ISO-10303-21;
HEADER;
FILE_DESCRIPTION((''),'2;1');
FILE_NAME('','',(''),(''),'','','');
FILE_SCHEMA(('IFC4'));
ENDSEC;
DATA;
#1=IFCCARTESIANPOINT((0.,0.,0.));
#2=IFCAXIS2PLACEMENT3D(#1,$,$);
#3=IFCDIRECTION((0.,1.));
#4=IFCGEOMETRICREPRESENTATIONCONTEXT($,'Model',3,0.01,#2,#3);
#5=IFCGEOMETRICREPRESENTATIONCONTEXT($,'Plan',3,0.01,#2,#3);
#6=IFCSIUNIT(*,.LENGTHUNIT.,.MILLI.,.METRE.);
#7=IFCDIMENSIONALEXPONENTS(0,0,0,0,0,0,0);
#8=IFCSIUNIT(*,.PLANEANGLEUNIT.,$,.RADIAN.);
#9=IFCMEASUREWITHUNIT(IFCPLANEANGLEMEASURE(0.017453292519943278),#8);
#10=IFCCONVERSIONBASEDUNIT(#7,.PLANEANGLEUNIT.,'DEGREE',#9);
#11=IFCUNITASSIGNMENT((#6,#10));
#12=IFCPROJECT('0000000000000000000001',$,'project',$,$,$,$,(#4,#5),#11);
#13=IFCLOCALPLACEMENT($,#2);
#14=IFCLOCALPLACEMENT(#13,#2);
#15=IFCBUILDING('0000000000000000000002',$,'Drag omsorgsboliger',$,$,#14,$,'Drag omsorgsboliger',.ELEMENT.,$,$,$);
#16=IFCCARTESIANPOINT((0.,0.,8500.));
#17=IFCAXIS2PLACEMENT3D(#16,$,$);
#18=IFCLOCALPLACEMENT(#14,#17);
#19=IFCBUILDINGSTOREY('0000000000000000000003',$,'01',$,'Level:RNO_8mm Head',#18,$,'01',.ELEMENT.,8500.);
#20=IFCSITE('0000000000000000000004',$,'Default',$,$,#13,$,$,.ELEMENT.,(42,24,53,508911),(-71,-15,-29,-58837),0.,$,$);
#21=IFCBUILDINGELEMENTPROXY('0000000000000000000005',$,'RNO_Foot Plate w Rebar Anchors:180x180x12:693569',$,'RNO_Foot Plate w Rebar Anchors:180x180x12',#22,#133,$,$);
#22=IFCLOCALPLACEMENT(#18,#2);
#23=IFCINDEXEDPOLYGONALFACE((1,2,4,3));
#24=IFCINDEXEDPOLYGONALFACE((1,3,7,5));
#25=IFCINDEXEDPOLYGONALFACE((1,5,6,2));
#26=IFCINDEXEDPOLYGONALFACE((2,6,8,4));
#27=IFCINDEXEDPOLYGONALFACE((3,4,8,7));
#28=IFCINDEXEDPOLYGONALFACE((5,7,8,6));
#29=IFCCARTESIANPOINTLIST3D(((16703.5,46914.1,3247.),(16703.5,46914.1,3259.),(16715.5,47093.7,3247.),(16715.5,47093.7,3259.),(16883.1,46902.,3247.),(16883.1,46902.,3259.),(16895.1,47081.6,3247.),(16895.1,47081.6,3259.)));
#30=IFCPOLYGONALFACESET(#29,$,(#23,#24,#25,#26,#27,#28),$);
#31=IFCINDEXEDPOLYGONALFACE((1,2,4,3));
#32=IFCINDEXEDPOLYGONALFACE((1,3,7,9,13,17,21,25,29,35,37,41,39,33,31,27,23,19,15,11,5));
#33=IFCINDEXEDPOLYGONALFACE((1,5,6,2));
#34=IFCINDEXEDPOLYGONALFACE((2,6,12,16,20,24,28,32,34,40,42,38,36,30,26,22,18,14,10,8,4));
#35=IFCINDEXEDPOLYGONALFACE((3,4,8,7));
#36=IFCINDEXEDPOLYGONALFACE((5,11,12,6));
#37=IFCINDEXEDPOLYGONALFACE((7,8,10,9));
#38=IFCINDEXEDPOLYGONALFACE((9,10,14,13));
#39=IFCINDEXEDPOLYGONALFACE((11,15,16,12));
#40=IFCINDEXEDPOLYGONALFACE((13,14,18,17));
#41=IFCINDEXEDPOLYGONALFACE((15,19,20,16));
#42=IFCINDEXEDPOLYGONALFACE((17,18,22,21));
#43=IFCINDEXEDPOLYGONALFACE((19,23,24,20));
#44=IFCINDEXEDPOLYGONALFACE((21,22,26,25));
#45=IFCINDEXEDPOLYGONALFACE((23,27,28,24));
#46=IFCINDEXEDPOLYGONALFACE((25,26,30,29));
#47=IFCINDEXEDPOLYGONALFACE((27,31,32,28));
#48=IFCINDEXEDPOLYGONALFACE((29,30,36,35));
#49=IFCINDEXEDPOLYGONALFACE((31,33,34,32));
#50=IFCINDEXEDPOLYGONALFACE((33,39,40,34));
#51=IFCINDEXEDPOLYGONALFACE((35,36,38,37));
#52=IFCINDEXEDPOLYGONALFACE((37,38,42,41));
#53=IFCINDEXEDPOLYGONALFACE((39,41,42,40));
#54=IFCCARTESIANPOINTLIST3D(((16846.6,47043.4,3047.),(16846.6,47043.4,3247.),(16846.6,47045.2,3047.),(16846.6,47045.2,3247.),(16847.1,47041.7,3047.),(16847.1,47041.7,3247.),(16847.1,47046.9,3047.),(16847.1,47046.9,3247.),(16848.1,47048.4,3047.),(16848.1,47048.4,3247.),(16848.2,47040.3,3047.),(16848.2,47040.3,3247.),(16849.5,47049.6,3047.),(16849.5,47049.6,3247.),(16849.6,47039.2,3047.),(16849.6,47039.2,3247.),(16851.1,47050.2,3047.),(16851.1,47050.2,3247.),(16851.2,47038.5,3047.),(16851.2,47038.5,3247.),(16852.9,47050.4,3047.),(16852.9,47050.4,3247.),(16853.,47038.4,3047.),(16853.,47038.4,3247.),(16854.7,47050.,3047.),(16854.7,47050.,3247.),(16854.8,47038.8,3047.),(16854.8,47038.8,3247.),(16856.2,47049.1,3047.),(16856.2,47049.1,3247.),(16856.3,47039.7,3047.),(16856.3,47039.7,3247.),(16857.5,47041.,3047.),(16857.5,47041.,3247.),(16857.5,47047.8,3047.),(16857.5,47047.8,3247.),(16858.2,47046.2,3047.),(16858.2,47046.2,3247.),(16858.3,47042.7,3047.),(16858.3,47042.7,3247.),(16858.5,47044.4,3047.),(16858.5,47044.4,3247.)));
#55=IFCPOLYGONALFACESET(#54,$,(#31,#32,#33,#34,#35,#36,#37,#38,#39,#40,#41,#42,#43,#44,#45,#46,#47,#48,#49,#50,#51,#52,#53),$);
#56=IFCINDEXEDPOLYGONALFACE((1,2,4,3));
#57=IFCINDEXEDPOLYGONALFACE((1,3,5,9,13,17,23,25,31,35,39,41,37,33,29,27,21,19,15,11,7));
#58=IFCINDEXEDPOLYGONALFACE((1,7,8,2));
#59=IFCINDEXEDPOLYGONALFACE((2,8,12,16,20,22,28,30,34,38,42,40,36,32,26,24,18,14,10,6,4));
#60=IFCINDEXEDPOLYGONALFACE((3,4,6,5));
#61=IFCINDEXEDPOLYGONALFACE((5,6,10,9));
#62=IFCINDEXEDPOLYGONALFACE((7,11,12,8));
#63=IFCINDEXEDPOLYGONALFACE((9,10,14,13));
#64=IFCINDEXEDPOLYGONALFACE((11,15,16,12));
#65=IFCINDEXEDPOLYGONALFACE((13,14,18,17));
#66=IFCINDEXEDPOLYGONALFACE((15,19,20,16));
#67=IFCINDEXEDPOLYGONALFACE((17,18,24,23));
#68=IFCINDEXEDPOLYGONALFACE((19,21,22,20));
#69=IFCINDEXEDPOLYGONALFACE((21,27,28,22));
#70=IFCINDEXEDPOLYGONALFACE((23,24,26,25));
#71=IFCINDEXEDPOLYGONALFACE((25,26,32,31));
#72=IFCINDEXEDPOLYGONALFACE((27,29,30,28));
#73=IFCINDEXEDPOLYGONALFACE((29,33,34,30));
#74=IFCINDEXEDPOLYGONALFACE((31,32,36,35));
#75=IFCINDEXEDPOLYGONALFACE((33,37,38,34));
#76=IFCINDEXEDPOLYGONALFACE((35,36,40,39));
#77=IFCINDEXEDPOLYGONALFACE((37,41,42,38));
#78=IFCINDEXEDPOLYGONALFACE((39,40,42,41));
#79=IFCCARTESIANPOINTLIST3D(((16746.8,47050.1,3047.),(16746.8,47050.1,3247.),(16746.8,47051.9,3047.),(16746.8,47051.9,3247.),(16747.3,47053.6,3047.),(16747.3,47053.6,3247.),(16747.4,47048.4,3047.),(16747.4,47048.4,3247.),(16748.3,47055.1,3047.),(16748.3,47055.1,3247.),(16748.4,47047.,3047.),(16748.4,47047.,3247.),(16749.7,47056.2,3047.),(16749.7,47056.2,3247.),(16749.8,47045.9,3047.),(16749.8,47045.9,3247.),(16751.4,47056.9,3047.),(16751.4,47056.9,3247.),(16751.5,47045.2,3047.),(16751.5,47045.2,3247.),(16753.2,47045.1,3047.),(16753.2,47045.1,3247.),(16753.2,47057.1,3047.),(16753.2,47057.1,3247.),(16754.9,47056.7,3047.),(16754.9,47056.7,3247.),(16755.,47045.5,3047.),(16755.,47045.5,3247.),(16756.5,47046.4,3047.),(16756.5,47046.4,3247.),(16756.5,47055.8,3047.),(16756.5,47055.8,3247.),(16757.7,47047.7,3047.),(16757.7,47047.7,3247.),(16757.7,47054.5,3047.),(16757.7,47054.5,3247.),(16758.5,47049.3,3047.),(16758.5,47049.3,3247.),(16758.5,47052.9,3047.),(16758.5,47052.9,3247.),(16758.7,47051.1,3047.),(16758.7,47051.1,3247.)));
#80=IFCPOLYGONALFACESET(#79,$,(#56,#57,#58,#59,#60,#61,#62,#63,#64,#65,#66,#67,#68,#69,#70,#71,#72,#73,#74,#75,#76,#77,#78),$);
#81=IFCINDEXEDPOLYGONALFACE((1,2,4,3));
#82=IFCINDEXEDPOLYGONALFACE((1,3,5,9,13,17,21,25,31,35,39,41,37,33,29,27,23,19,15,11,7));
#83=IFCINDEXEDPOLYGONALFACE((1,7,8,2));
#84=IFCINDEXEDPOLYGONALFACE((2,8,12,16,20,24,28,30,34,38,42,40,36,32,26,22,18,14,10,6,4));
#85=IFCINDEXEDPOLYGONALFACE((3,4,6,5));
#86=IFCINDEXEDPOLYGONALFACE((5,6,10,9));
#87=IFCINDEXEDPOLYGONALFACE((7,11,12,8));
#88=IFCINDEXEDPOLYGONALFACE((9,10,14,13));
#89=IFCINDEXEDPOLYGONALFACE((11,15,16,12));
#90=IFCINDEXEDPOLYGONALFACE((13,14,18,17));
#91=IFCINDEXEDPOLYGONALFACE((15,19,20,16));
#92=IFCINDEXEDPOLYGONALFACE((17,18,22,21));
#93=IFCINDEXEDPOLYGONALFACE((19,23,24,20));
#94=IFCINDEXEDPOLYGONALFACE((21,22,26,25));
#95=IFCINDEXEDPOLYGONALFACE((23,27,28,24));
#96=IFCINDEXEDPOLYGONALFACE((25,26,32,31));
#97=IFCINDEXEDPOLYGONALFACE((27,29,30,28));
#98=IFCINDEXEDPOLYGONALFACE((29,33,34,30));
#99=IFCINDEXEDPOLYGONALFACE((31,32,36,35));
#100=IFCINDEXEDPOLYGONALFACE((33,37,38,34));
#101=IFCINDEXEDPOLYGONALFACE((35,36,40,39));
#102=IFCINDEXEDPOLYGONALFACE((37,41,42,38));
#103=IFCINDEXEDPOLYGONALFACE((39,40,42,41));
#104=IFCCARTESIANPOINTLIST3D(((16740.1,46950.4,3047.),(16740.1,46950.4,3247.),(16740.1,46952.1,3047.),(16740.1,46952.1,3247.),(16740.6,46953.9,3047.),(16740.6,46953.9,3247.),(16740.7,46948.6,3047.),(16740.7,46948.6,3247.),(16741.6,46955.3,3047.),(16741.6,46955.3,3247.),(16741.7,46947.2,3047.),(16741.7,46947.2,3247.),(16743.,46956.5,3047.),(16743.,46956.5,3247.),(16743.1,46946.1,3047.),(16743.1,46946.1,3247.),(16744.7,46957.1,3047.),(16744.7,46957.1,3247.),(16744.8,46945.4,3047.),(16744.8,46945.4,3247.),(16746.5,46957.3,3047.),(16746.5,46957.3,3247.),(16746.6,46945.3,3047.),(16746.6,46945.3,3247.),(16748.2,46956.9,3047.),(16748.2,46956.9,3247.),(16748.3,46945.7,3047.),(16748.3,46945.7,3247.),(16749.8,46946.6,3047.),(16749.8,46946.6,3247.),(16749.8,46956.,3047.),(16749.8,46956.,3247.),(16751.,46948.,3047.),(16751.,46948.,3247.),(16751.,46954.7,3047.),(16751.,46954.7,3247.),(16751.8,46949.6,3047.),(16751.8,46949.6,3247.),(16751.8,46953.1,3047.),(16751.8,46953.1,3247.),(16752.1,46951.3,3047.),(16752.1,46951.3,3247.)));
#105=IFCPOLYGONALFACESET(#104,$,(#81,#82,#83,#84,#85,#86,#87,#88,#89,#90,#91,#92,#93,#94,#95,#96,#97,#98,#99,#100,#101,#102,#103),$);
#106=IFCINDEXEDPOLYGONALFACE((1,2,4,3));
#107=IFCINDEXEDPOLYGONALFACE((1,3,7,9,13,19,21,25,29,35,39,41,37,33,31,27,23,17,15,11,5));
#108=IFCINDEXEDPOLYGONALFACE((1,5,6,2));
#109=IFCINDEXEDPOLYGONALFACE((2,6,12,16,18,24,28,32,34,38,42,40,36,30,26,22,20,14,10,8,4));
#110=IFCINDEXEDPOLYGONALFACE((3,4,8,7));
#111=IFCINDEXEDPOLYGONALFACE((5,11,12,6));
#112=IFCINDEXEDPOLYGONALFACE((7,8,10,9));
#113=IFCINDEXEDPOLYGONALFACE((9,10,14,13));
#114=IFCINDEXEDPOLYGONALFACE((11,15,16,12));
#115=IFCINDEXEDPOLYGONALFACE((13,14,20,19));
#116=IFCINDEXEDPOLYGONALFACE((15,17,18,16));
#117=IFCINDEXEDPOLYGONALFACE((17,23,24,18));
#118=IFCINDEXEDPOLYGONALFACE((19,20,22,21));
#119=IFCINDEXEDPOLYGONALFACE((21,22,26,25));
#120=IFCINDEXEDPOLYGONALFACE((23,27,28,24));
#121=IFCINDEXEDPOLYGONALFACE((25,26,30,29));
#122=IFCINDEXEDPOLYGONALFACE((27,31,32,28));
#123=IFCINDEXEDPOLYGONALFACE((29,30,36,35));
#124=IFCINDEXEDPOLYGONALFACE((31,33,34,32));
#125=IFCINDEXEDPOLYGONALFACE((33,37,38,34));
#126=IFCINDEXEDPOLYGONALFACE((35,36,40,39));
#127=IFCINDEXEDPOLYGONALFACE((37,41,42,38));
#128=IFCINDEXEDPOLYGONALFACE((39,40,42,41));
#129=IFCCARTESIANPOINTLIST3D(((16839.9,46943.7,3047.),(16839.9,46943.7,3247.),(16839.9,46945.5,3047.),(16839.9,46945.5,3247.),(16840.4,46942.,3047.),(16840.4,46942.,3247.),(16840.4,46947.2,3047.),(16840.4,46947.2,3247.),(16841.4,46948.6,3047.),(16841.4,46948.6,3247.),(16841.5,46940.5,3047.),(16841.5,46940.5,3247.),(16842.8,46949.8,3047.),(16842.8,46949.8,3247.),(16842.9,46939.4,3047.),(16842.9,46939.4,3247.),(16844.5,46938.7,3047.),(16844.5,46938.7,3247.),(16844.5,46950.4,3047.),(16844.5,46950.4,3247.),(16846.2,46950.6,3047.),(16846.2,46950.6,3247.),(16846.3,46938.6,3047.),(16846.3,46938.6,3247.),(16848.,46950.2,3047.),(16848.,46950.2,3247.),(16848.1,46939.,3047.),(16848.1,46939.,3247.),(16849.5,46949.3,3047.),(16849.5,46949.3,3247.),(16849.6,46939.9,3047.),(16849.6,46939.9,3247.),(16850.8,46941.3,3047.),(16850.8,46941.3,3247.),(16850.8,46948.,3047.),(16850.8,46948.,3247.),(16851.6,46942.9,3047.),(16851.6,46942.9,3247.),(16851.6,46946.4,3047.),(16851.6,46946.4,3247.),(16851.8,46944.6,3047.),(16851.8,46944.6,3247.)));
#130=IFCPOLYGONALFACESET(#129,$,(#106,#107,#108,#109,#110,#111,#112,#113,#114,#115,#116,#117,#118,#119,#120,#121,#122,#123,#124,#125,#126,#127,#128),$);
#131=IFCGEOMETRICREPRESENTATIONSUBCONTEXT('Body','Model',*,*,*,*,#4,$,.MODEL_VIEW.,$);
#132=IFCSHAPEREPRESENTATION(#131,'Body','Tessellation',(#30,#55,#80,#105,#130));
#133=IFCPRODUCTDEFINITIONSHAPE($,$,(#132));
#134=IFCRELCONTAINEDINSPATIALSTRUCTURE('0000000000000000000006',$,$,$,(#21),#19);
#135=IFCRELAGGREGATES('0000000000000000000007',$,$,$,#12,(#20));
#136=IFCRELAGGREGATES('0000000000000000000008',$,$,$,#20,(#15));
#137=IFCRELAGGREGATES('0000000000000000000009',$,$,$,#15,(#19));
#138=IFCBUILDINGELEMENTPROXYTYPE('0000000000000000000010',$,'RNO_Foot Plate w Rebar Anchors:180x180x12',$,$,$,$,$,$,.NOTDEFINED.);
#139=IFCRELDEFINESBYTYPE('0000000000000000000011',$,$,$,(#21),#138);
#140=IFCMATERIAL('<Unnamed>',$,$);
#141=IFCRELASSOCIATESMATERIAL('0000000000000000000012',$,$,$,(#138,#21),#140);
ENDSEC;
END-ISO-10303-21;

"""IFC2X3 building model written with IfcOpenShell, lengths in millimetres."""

from ifc_helpers import new_model, entity, si_unit, converted_unit, direction, frame, frame_2d, origin, origin_2d_with_axis, place, context, subcontext, project, spatial, rectangle, circle, extrude, source, transform, mapped, material, type_object, type_shapes, element, save


model = new_model("IFC2X3")

# Units and contexts
model_context = context("Model", 3, precision=0.01, world=origin(), true_north=direction((0.0, 1.0)))
plan_context = context("Plan", 3, precision=0.01, world=origin(), true_north=direction((0.0, 1.0)))
body_context = subcontext(model_context, "Body", "Model", "MODEL_VIEW")
ifc_project = project(units=[si_unit("LENGTHUNIT", "METRE", prefix="MILLI"), converted_unit("PLANEANGLEUNIT", "DEGREE", entity("IfcPlaneAngleMeasure", 0.017453292519943278), si_unit("PLANEANGLEUNIT", "RADIAN"), dimensions=[0, 0, 0, 0, 0, 0, 0])], contexts=[model_context, plan_context])

# Site, building, storey
site_placement = place(None, origin())
site = spatial("IfcSite", under=ifc_project, at=site_placement, Name="Default", CompositionType="ELEMENT", RefLatitude=(42, 24, 53, 508911), RefLongitude=(-71, -15, -29, -58837), RefElevation=0.0)
building_placement = place(site_placement, origin())
building = spatial("IfcBuilding", under=site, at=building_placement, Name="Drag omsorgsboliger", LongName="Drag omsorgsboliger", CompositionType="ELEMENT")
storey_placement = place(building_placement, frame((0.0, 0.0, 8500.0)))
storey = spatial("IfcBuildingStorey", under=building, at=storey_placement, Name="01", ObjectType="Level:RNO_8mm Head", LongName="01", CompositionType="ELEMENT", Elevation=8500.0)

# Building element proxy
ifc_material_1 = material(Name="<Unnamed>")
building_element_proxy_type_1 = type_object("IfcBuildingElementProxyType", Name="RNO_Foot Plate w Rebar Anchors:180x180x12", PredefinedType="NOTDEFINED", material=ifc_material_1)
shared_shape_1 = source(origin(), body_context, "Body", "SweptSolid", [
    extrude(rectangle(XDim=180.0, YDim=180.0, at=origin_2d_with_axis()), frame((-90.0, 20.0, -12.0), z_axis=(0.0, 0.0, 1.0), x_axis=(-1.0, 0.0, 0.0)), (0.0, 0.0, 1.0), 12.0),
    extrude(circle(Radius=6.0, at=frame_2d((0.0, 0.0), x_axis=(1.0, 0.0))), frame((-40.0, -30.0, -212.0)), (0.0, 0.0, 1.0), 200.0),
    extrude(circle(Radius=6.0, at=frame_2d((0.0, 0.0), x_axis=(1.0, 0.0))), frame((-40.0, 70.0, -212.0)), (0.0, 0.0, 1.0), 200.0),
    extrude(circle(Radius=6.0, at=frame_2d((0.0, 0.0), x_axis=(1.0, 0.0))), frame((-140.0, 70.0, -212.0)), (0.0, 0.0, 1.0), 200.0),
    extrude(circle(Radius=6.0, at=frame_2d((0.0, 0.0), x_axis=(1.0, 0.0))), frame((-140.0, -30.0, -212.0)), (0.0, 0.0, 1.0), 200.0),
])
type_shapes(building_element_proxy_type_1, [shared_shape_1])
for number, where, z_axis, x_axis, name in (
    (1, (16825.3, 47086.3, 3259.0), (0.0, 0.0, 1.0), (0.066923, 0.997758, 0.0), "RNO_Foot Plate w Rebar Anchors:180x180x12:693569"),
):
    element("IfcBuildingElementProxy", number, at=place(storey_placement, frame(where, z_axis=z_axis, x_axis=x_axis)), inside=storey, type_object=building_element_proxy_type_1, material=ifc_material_1, Name=name, ObjectType="RNO_Foot Plate w Rebar Anchors:180x180x12", context=body_context, shape_type="MappedRepresentation", body=[
        mapped(shared_shape_1, transform((0.0, 0.0, 0.0), scale=1.0)),
    ])

save(model, "model.ifc")
